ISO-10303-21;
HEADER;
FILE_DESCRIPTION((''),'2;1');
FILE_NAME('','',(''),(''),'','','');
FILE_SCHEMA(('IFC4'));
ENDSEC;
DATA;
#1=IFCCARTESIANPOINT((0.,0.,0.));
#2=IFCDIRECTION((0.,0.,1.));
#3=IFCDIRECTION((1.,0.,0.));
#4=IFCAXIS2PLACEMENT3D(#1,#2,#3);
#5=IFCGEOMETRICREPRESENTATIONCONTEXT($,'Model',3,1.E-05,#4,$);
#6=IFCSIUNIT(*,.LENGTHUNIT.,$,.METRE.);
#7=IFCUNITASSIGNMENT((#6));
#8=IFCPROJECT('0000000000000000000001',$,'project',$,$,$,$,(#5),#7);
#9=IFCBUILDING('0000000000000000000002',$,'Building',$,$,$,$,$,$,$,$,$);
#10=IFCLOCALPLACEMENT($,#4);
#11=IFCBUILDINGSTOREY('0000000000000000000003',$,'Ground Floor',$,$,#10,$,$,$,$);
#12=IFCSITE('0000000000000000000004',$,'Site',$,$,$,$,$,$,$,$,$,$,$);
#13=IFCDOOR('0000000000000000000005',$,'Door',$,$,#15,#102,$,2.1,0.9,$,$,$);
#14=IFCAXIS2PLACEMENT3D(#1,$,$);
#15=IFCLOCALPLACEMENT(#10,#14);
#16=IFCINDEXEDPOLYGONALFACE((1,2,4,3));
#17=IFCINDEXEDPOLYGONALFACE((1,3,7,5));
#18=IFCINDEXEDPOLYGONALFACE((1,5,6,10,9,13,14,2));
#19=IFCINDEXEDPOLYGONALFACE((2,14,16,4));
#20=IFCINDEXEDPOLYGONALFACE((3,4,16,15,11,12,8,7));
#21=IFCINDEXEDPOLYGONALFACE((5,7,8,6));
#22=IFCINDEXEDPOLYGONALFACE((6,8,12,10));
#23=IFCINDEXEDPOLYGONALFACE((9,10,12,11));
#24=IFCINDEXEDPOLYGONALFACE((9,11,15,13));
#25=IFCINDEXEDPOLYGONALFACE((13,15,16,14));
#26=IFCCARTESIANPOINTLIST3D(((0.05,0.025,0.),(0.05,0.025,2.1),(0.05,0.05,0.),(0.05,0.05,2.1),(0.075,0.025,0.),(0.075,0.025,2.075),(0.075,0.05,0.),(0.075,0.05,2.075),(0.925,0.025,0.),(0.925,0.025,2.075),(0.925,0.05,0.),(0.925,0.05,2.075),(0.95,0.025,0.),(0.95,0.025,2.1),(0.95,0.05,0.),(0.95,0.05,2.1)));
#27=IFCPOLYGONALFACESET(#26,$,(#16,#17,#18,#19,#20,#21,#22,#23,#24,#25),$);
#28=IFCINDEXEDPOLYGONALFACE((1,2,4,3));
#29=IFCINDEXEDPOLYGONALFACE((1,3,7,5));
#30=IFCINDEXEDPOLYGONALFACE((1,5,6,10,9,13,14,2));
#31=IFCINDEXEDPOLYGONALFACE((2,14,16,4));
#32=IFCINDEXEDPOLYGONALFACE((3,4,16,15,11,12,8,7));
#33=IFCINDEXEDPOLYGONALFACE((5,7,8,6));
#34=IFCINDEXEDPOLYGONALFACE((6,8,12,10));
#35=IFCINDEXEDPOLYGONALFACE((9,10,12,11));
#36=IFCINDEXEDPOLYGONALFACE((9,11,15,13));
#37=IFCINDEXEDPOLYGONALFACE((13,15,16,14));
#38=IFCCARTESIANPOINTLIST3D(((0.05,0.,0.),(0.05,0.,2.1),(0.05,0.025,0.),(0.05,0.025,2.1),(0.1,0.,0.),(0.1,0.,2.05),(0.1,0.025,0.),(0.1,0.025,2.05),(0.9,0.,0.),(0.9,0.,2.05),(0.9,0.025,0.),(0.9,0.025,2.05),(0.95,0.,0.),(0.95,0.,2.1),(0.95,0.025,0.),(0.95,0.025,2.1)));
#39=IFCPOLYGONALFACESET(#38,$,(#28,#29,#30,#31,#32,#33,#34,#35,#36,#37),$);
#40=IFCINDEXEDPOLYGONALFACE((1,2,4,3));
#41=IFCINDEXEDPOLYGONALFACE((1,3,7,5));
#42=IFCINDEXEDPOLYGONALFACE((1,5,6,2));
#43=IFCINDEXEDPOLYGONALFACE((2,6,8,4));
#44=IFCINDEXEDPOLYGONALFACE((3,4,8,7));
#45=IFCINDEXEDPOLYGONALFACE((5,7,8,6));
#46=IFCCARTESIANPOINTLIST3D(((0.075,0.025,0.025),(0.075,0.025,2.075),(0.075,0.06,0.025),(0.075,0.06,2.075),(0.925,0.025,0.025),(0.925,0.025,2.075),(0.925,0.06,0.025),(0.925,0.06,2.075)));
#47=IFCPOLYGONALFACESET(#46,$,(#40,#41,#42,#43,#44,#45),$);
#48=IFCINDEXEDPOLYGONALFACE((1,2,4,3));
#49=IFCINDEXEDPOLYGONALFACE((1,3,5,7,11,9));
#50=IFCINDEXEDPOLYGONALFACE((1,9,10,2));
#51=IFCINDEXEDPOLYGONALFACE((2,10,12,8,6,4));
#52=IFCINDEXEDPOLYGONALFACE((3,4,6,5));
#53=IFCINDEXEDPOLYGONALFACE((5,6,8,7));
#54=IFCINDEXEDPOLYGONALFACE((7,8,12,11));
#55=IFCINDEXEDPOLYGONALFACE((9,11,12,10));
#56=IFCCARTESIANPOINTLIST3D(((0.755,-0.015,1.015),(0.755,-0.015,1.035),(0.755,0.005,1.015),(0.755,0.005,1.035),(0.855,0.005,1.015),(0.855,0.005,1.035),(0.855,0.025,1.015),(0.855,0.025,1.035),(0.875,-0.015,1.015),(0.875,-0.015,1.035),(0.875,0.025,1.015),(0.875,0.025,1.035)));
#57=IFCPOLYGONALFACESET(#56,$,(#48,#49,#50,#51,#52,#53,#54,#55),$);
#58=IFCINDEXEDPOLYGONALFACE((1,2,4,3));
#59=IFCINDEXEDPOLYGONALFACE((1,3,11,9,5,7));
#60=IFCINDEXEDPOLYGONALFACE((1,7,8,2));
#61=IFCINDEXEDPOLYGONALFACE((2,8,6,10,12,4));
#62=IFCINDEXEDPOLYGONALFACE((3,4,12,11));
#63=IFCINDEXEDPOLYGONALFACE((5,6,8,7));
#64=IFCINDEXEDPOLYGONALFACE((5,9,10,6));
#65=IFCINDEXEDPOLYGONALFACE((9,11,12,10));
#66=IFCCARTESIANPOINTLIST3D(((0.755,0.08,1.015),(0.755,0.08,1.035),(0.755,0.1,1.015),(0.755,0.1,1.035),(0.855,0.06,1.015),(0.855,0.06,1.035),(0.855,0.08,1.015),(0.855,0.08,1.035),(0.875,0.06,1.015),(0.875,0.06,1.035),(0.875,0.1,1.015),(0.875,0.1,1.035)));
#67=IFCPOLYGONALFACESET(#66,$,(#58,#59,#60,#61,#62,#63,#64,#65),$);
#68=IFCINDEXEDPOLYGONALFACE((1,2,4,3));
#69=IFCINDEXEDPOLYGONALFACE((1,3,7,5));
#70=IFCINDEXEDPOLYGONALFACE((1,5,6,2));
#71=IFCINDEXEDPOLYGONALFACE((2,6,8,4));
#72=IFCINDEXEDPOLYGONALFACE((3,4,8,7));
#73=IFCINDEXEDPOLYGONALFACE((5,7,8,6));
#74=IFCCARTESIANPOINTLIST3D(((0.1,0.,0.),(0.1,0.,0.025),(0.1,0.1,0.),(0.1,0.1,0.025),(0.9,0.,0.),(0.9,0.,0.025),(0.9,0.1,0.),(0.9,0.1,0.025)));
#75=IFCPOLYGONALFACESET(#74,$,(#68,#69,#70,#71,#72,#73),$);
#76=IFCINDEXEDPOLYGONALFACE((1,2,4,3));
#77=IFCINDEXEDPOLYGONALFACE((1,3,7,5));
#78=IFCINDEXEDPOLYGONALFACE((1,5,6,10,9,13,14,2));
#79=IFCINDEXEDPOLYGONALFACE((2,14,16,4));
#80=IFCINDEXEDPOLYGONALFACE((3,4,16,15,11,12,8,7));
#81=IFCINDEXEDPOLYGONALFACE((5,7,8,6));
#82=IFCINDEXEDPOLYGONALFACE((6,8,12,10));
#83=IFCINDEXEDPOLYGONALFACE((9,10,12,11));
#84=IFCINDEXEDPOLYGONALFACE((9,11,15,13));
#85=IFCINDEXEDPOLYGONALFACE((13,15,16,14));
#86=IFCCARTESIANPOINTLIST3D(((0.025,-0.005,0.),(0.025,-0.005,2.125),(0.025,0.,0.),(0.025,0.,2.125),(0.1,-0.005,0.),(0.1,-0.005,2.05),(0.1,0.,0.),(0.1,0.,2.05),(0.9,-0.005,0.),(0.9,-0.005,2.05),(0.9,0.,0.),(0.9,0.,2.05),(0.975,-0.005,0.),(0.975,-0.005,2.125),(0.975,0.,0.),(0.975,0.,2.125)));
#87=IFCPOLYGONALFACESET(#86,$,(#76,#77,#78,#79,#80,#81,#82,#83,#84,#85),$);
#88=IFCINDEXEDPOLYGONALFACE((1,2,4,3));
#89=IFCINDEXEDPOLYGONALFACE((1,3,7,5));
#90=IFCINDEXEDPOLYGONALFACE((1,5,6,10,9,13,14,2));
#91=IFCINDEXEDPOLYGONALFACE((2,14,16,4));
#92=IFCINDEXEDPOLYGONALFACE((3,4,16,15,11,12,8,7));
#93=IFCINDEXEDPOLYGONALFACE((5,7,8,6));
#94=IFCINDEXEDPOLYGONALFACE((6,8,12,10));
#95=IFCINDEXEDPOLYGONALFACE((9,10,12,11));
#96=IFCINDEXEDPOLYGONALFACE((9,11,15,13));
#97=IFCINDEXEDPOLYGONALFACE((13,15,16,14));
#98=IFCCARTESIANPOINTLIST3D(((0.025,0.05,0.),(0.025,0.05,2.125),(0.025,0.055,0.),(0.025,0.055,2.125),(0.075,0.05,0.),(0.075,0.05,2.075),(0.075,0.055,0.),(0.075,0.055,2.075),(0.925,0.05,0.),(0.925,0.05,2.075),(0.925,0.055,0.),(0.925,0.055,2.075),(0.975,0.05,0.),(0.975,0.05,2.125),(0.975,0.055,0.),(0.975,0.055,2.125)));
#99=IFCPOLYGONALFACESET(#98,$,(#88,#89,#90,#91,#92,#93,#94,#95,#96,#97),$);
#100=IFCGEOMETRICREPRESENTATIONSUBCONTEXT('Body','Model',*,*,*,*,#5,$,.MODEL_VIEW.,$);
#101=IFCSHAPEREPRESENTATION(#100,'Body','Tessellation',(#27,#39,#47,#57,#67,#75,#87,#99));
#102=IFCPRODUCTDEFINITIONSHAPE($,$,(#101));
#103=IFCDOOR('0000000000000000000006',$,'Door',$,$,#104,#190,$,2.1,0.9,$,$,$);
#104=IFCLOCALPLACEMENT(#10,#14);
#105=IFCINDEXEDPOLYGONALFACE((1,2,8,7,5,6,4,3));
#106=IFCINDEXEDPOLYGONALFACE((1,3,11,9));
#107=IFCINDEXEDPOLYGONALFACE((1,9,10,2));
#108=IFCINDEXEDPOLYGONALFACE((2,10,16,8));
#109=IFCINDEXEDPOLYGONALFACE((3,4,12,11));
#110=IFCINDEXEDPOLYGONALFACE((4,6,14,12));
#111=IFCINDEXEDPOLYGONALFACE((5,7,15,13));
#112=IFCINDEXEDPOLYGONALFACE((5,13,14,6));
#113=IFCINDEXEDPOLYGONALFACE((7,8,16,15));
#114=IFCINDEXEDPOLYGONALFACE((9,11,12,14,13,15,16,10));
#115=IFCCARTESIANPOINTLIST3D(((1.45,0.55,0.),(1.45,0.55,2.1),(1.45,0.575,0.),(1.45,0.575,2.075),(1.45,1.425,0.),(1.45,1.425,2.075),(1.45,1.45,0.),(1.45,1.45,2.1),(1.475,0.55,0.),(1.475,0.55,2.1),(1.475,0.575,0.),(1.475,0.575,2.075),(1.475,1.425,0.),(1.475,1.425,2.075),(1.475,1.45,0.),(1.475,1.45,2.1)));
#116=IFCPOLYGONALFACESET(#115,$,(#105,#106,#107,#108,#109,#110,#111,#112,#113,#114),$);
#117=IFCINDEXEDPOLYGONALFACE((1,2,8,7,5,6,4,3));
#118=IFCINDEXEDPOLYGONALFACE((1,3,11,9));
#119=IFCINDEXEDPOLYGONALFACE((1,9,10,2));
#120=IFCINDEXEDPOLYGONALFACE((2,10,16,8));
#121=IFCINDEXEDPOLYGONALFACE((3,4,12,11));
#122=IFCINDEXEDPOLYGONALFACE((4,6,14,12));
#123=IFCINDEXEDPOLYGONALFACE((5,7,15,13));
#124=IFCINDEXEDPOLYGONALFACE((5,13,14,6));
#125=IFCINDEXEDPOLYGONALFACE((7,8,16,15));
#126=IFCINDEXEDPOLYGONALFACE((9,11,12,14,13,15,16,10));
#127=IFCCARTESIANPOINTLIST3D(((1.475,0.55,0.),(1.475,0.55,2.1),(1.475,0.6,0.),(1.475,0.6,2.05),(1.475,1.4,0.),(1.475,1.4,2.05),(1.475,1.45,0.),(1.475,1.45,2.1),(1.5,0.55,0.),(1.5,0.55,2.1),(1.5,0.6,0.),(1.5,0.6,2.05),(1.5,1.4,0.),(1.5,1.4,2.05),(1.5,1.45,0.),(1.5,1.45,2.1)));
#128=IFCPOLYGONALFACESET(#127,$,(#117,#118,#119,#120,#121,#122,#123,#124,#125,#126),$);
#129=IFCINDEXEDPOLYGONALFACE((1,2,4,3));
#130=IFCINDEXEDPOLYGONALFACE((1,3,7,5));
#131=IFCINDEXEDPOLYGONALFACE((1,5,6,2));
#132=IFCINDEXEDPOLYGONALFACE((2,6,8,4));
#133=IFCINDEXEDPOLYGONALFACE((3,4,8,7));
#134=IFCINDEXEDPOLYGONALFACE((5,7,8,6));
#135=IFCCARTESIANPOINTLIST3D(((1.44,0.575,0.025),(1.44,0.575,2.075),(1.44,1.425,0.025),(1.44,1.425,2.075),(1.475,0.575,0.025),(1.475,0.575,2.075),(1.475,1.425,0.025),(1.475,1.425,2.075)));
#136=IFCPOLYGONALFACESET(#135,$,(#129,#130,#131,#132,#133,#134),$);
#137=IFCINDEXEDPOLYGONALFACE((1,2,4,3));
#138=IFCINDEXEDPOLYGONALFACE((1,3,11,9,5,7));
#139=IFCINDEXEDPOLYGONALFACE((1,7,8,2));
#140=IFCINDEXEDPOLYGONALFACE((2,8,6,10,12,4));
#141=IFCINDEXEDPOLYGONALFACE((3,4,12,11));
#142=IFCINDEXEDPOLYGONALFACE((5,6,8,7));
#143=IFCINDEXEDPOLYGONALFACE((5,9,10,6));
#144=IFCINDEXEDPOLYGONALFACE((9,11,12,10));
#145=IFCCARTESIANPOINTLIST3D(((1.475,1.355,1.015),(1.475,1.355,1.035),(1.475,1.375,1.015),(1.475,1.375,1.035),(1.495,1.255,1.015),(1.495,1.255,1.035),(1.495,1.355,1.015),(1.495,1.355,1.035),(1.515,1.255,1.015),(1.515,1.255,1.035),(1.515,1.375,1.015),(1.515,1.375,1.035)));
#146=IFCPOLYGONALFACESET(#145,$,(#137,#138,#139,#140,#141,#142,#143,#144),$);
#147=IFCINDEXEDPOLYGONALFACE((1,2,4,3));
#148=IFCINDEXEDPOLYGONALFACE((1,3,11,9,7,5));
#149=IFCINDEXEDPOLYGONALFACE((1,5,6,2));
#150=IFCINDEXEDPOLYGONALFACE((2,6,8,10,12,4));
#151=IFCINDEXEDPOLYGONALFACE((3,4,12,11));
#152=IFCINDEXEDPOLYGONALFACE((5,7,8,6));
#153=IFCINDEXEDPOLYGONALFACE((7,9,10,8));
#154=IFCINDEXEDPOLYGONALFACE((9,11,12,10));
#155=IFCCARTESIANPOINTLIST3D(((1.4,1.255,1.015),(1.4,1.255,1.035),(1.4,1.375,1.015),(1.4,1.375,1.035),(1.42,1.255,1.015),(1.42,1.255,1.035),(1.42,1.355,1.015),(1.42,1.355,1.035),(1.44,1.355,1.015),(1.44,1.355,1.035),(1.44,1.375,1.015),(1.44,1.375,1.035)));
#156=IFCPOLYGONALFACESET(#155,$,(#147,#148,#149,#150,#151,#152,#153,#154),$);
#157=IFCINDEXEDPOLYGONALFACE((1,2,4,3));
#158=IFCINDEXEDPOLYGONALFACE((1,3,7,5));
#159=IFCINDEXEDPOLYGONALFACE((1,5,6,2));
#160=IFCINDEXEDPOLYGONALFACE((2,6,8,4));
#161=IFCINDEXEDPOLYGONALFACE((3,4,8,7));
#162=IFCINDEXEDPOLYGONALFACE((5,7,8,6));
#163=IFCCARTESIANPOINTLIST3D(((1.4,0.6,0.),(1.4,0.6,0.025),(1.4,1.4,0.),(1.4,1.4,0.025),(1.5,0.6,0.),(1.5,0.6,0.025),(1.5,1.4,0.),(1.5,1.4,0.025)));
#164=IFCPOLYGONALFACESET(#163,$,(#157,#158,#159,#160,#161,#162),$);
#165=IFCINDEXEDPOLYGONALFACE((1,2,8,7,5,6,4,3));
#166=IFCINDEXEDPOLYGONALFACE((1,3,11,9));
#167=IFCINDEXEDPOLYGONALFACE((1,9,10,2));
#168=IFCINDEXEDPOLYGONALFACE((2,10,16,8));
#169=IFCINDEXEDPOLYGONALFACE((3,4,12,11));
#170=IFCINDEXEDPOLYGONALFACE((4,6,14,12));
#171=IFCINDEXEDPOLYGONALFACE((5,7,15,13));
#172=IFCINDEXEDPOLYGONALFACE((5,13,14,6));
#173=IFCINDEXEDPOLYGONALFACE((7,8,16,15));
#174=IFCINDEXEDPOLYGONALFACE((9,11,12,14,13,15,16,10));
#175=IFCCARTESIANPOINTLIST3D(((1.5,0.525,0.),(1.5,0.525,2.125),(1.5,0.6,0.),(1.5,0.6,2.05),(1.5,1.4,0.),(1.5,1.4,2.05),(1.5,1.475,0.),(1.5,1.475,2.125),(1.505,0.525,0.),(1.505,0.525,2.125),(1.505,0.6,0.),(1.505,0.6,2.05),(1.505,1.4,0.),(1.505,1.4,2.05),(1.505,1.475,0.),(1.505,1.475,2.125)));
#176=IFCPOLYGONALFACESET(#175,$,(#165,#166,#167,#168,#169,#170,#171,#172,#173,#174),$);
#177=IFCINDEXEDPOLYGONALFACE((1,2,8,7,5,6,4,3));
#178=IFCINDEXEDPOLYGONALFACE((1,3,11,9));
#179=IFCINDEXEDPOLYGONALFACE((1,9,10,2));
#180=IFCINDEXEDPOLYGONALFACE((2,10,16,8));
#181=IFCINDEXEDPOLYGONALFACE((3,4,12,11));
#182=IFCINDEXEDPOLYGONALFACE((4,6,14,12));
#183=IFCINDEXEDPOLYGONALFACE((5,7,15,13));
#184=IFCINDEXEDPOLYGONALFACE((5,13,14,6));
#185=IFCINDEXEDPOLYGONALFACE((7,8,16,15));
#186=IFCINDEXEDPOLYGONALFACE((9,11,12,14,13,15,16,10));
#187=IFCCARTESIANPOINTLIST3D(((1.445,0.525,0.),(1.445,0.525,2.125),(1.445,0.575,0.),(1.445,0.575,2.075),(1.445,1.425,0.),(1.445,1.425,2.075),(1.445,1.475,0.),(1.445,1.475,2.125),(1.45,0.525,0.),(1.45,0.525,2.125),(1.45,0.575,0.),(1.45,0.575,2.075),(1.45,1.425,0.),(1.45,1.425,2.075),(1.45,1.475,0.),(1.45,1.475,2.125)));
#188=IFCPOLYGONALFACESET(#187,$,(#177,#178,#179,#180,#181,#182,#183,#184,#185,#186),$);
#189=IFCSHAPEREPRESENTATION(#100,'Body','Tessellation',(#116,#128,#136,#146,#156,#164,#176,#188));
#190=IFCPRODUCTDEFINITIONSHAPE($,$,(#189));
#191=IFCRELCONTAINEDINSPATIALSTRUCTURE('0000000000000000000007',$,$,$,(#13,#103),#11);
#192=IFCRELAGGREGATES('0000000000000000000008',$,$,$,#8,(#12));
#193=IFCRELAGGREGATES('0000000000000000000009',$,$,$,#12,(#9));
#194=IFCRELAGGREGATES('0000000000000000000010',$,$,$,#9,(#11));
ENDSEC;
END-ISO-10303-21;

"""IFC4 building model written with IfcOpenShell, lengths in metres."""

from ifc_helpers import new_model, si_unit, frame, origin_with_axes, place, context, subcontext, project, spatial, line, indexed_curve, outline, extrude, element, save


model = new_model("IFC4")

# Units and contexts
model_context = context("Model", 3, precision=1e-05, world=origin_with_axes())
body_context = subcontext(model_context, "Body", "Model", "MODEL_VIEW")
ifc_project = project(units=[si_unit("LENGTHUNIT", "METRE")], contexts=[model_context])

# Site, building, storey
site = spatial("IfcSite", under=ifc_project, Name="Site")
building = spatial("IfcBuilding", under=site, Name="Building")
storey_placement = place(None, origin_with_axes())
storey = spatial("IfcBuildingStorey", under=building, at=storey_placement, Name="Ground Floor")

# Doors
door_1_placement = place(storey_placement, frame((0.05, 0.0, 0.0), z_axis=(0.0, 0.0, 1.0), x_axis=(1.0, 0.0, 0.0)))
element("IfcDoor", 1, at=door_1_placement, inside=storey, Name="Door", OverallHeight=2.1, OverallWidth=0.9, context=body_context, shape_type="SweptSolid", body=[
    extrude(outline(indexed_curve([(0.0, 0.0), (0.0, 2.1), (0.9, 2.1), (0.9, 0.0), (0.875, 0.0), (0.875, 2.075), (0.025, 2.075), (0.025, 0.0)], segments=[line(1, 2, 3, 4, 5, 6, 7, 8, 1)])), frame((0.0, 0.025, 0.0), z_axis=(0.0, -1.0, 0.0), x_axis=(1.0, 0.0, 0.0)), (0.0, 0.0, -1.0), 0.025),
    extrude(outline(indexed_curve([(0.0, 0.0), (0.0, 2.1), (0.9, 2.1), (0.9, 0.0), (0.85, 0.0), (0.85, 2.05), (0.05, 2.05), (0.05, 0.0)], segments=[line(1, 2, 3, 4, 5, 6, 7, 8, 1)])), frame((0.0, 0.0, 0.0), z_axis=(0.0, -1.0, 0.0), x_axis=(1.0, 0.0, 0.0)), (0.0, 0.0, -1.0), 0.025),
    extrude(outline(indexed_curve([(0.0, 0.0), (0.85, 0.0), (0.85, 0.035), (0.0, 0.035)], segments=[line(1, 2, 3, 4, 1)])), frame((0.025, 0.025, 0.025), z_axis=(0.0, 0.0, 1.0), x_axis=(1.0, 0.0, 0.0)), (0.0, 0.0, 1.0), 2.05),
    extrude(outline(indexed_curve([(0.0, 0.0), (0.0, -0.04), (-0.12, -0.04), (-0.12, -0.02), (-0.02, -0.02), (-0.02, 0.0)], segments=[line(1, 2, 3, 4, 5, 6, 1)])), frame((0.825, 0.025, 1.015), z_axis=(0.0, 0.0, 1.0), x_axis=(1.0, 0.0, 0.0)), (0.0, 0.0, 1.0), 0.02),
    extrude(outline(indexed_curve([(0.0, 0.0), (0.0, 0.04), (-0.12, 0.04), (-0.12, 0.02), (-0.02, 0.02), (-0.02, 0.0)], segments=[line(1, 2, 3, 4, 5, 6, 1)])), frame((0.825, 0.06, 1.015), z_axis=(0.0, 0.0, 1.0), x_axis=(1.0, 0.0, 0.0)), (0.0, 0.0, 1.0), 0.02),
    extrude(outline(indexed_curve([(0.0, 0.0), (0.8, 0.0), (0.8, 0.1), (0.0, 0.1)], segments=[line(1, 2, 3, 4, 1)])), frame((0.05, 0.0, 0.0), z_axis=(0.0, 0.0, 1.0), x_axis=(1.0, 0.0, 0.0)), (0.0, 0.0, 1.0), 0.025),
    extrude(outline(indexed_curve([(0.0, 0.0), (0.0, 2.125), (0.95, 2.125), (0.95, 0.0), (0.875, 0.0), (0.875, 2.05), (0.075, 2.05), (0.075, 0.0)], segments=[line(1, 2, 3, 4, 5, 6, 7, 8, 1)])), frame((-0.025, -0.005, 0.0), z_axis=(0.0, -1.0, 0.0), x_axis=(1.0, 0.0, 0.0)), (0.0, 0.0, -1.0), 0.005),
    extrude(outline(indexed_curve([(0.0, 0.0), (0.0, 2.125), (0.95, 2.125), (0.95, 0.0), (0.9, 0.0), (0.9, 2.075), (0.05, 2.075), (0.05, 0.0)], segments=[line(1, 2, 3, 4, 5, 6, 7, 8, 1)])), frame((-0.025, 0.05, 0.0), z_axis=(0.0, -1.0, 0.0), x_axis=(1.0, 0.0, 0.0)), (0.0, 0.0, -1.0), 0.005),
])
door_2_placement = place(storey_placement, frame((1.5, 0.55, 0.0), z_axis=(0.0, 0.0, 1.0), x_axis=(0.0, 1.0, 0.0)))
element("IfcDoor", 2, at=door_2_placement, inside=storey, Name="Door", OverallHeight=2.1, OverallWidth=0.9, context=body_context, shape_type="SweptSolid", body=[
    extrude(outline(indexed_curve([(0.0, 0.0), (0.0, 2.1), (0.9, 2.1), (0.9, 0.0), (0.875, 0.0), (0.875, 2.075), (0.025, 2.075), (0.025, 0.0)], segments=[line(1, 2, 3, 4, 5, 6, 7, 8, 1)])), frame((0.0, 0.025, 0.0), z_axis=(0.0, -1.0, 0.0), x_axis=(1.0, 0.0, 0.0)), (0.0, 0.0, -1.0), 0.025),
    extrude(outline(indexed_curve([(0.0, 0.0), (0.0, 2.1), (0.9, 2.1), (0.9, 0.0), (0.85, 0.0), (0.85, 2.05), (0.05, 2.05), (0.05, 0.0)], segments=[line(1, 2, 3, 4, 5, 6, 7, 8, 1)])), frame((0.0, 0.0, 0.0), z_axis=(0.0, -1.0, 0.0), x_axis=(1.0, 0.0, 0.0)), (0.0, 0.0, -1.0), 0.025),
    extrude(outline(indexed_curve([(0.0, 0.0), (0.85, 0.0), (0.85, 0.035), (0.0, 0.035)], segments=[line(1, 2, 3, 4, 1)])), frame((0.025, 0.025, 0.025), z_axis=(0.0, 0.0, 1.0), x_axis=(1.0, 0.0, 0.0)), (0.0, 0.0, 1.0), 2.05),
    extrude(outline(indexed_curve([(0.0, 0.0), (0.0, -0.04), (-0.12, -0.04), (-0.12, -0.02), (-0.02, -0.02), (-0.02, 0.0)], segments=[line(1, 2, 3, 4, 5, 6, 1)])), frame((0.825, 0.025, 1.015), z_axis=(0.0, 0.0, 1.0), x_axis=(1.0, 0.0, 0.0)), (0.0, 0.0, 1.0), 0.02),
    extrude(outline(indexed_curve([(0.0, 0.0), (0.0, 0.04), (-0.12, 0.04), (-0.12, 0.02), (-0.02, 0.02), (-0.02, 0.0)], segments=[line(1, 2, 3, 4, 5, 6, 1)])), frame((0.825, 0.06, 1.015), z_axis=(0.0, 0.0, 1.0), x_axis=(1.0, 0.0, 0.0)), (0.0, 0.0, 1.0), 0.02),
    extrude(outline(indexed_curve([(0.0, 0.0), (0.8, 0.0), (0.8, 0.1), (0.0, 0.1)], segments=[line(1, 2, 3, 4, 1)])), frame((0.05, 0.0, 0.0), z_axis=(0.0, 0.0, 1.0), x_axis=(1.0, 0.0, 0.0)), (0.0, 0.0, 1.0), 0.025),
    extrude(outline(indexed_curve([(0.0, 0.0), (0.0, 2.125), (0.95, 2.125), (0.95, 0.0), (0.875, 0.0), (0.875, 2.05), (0.075, 2.05), (0.075, 0.0)], segments=[line(1, 2, 3, 4, 5, 6, 7, 8, 1)])), frame((-0.025, -0.005, 0.0), z_axis=(0.0, -1.0, 0.0), x_axis=(1.0, 0.0, 0.0)), (0.0, 0.0, -1.0), 0.005),
    extrude(outline(indexed_curve([(0.0, 0.0), (0.0, 2.125), (0.95, 2.125), (0.95, 0.0), (0.9, 0.0), (0.9, 2.075), (0.05, 2.075), (0.05, 0.0)], segments=[line(1, 2, 3, 4, 5, 6, 7, 8, 1)])), frame((-0.025, 0.05, 0.0), z_axis=(0.0, -1.0, 0.0), x_axis=(1.0, 0.0, 0.0)), (0.0, 0.0, -1.0), 0.005),
])

save(model, "model.ifc")
